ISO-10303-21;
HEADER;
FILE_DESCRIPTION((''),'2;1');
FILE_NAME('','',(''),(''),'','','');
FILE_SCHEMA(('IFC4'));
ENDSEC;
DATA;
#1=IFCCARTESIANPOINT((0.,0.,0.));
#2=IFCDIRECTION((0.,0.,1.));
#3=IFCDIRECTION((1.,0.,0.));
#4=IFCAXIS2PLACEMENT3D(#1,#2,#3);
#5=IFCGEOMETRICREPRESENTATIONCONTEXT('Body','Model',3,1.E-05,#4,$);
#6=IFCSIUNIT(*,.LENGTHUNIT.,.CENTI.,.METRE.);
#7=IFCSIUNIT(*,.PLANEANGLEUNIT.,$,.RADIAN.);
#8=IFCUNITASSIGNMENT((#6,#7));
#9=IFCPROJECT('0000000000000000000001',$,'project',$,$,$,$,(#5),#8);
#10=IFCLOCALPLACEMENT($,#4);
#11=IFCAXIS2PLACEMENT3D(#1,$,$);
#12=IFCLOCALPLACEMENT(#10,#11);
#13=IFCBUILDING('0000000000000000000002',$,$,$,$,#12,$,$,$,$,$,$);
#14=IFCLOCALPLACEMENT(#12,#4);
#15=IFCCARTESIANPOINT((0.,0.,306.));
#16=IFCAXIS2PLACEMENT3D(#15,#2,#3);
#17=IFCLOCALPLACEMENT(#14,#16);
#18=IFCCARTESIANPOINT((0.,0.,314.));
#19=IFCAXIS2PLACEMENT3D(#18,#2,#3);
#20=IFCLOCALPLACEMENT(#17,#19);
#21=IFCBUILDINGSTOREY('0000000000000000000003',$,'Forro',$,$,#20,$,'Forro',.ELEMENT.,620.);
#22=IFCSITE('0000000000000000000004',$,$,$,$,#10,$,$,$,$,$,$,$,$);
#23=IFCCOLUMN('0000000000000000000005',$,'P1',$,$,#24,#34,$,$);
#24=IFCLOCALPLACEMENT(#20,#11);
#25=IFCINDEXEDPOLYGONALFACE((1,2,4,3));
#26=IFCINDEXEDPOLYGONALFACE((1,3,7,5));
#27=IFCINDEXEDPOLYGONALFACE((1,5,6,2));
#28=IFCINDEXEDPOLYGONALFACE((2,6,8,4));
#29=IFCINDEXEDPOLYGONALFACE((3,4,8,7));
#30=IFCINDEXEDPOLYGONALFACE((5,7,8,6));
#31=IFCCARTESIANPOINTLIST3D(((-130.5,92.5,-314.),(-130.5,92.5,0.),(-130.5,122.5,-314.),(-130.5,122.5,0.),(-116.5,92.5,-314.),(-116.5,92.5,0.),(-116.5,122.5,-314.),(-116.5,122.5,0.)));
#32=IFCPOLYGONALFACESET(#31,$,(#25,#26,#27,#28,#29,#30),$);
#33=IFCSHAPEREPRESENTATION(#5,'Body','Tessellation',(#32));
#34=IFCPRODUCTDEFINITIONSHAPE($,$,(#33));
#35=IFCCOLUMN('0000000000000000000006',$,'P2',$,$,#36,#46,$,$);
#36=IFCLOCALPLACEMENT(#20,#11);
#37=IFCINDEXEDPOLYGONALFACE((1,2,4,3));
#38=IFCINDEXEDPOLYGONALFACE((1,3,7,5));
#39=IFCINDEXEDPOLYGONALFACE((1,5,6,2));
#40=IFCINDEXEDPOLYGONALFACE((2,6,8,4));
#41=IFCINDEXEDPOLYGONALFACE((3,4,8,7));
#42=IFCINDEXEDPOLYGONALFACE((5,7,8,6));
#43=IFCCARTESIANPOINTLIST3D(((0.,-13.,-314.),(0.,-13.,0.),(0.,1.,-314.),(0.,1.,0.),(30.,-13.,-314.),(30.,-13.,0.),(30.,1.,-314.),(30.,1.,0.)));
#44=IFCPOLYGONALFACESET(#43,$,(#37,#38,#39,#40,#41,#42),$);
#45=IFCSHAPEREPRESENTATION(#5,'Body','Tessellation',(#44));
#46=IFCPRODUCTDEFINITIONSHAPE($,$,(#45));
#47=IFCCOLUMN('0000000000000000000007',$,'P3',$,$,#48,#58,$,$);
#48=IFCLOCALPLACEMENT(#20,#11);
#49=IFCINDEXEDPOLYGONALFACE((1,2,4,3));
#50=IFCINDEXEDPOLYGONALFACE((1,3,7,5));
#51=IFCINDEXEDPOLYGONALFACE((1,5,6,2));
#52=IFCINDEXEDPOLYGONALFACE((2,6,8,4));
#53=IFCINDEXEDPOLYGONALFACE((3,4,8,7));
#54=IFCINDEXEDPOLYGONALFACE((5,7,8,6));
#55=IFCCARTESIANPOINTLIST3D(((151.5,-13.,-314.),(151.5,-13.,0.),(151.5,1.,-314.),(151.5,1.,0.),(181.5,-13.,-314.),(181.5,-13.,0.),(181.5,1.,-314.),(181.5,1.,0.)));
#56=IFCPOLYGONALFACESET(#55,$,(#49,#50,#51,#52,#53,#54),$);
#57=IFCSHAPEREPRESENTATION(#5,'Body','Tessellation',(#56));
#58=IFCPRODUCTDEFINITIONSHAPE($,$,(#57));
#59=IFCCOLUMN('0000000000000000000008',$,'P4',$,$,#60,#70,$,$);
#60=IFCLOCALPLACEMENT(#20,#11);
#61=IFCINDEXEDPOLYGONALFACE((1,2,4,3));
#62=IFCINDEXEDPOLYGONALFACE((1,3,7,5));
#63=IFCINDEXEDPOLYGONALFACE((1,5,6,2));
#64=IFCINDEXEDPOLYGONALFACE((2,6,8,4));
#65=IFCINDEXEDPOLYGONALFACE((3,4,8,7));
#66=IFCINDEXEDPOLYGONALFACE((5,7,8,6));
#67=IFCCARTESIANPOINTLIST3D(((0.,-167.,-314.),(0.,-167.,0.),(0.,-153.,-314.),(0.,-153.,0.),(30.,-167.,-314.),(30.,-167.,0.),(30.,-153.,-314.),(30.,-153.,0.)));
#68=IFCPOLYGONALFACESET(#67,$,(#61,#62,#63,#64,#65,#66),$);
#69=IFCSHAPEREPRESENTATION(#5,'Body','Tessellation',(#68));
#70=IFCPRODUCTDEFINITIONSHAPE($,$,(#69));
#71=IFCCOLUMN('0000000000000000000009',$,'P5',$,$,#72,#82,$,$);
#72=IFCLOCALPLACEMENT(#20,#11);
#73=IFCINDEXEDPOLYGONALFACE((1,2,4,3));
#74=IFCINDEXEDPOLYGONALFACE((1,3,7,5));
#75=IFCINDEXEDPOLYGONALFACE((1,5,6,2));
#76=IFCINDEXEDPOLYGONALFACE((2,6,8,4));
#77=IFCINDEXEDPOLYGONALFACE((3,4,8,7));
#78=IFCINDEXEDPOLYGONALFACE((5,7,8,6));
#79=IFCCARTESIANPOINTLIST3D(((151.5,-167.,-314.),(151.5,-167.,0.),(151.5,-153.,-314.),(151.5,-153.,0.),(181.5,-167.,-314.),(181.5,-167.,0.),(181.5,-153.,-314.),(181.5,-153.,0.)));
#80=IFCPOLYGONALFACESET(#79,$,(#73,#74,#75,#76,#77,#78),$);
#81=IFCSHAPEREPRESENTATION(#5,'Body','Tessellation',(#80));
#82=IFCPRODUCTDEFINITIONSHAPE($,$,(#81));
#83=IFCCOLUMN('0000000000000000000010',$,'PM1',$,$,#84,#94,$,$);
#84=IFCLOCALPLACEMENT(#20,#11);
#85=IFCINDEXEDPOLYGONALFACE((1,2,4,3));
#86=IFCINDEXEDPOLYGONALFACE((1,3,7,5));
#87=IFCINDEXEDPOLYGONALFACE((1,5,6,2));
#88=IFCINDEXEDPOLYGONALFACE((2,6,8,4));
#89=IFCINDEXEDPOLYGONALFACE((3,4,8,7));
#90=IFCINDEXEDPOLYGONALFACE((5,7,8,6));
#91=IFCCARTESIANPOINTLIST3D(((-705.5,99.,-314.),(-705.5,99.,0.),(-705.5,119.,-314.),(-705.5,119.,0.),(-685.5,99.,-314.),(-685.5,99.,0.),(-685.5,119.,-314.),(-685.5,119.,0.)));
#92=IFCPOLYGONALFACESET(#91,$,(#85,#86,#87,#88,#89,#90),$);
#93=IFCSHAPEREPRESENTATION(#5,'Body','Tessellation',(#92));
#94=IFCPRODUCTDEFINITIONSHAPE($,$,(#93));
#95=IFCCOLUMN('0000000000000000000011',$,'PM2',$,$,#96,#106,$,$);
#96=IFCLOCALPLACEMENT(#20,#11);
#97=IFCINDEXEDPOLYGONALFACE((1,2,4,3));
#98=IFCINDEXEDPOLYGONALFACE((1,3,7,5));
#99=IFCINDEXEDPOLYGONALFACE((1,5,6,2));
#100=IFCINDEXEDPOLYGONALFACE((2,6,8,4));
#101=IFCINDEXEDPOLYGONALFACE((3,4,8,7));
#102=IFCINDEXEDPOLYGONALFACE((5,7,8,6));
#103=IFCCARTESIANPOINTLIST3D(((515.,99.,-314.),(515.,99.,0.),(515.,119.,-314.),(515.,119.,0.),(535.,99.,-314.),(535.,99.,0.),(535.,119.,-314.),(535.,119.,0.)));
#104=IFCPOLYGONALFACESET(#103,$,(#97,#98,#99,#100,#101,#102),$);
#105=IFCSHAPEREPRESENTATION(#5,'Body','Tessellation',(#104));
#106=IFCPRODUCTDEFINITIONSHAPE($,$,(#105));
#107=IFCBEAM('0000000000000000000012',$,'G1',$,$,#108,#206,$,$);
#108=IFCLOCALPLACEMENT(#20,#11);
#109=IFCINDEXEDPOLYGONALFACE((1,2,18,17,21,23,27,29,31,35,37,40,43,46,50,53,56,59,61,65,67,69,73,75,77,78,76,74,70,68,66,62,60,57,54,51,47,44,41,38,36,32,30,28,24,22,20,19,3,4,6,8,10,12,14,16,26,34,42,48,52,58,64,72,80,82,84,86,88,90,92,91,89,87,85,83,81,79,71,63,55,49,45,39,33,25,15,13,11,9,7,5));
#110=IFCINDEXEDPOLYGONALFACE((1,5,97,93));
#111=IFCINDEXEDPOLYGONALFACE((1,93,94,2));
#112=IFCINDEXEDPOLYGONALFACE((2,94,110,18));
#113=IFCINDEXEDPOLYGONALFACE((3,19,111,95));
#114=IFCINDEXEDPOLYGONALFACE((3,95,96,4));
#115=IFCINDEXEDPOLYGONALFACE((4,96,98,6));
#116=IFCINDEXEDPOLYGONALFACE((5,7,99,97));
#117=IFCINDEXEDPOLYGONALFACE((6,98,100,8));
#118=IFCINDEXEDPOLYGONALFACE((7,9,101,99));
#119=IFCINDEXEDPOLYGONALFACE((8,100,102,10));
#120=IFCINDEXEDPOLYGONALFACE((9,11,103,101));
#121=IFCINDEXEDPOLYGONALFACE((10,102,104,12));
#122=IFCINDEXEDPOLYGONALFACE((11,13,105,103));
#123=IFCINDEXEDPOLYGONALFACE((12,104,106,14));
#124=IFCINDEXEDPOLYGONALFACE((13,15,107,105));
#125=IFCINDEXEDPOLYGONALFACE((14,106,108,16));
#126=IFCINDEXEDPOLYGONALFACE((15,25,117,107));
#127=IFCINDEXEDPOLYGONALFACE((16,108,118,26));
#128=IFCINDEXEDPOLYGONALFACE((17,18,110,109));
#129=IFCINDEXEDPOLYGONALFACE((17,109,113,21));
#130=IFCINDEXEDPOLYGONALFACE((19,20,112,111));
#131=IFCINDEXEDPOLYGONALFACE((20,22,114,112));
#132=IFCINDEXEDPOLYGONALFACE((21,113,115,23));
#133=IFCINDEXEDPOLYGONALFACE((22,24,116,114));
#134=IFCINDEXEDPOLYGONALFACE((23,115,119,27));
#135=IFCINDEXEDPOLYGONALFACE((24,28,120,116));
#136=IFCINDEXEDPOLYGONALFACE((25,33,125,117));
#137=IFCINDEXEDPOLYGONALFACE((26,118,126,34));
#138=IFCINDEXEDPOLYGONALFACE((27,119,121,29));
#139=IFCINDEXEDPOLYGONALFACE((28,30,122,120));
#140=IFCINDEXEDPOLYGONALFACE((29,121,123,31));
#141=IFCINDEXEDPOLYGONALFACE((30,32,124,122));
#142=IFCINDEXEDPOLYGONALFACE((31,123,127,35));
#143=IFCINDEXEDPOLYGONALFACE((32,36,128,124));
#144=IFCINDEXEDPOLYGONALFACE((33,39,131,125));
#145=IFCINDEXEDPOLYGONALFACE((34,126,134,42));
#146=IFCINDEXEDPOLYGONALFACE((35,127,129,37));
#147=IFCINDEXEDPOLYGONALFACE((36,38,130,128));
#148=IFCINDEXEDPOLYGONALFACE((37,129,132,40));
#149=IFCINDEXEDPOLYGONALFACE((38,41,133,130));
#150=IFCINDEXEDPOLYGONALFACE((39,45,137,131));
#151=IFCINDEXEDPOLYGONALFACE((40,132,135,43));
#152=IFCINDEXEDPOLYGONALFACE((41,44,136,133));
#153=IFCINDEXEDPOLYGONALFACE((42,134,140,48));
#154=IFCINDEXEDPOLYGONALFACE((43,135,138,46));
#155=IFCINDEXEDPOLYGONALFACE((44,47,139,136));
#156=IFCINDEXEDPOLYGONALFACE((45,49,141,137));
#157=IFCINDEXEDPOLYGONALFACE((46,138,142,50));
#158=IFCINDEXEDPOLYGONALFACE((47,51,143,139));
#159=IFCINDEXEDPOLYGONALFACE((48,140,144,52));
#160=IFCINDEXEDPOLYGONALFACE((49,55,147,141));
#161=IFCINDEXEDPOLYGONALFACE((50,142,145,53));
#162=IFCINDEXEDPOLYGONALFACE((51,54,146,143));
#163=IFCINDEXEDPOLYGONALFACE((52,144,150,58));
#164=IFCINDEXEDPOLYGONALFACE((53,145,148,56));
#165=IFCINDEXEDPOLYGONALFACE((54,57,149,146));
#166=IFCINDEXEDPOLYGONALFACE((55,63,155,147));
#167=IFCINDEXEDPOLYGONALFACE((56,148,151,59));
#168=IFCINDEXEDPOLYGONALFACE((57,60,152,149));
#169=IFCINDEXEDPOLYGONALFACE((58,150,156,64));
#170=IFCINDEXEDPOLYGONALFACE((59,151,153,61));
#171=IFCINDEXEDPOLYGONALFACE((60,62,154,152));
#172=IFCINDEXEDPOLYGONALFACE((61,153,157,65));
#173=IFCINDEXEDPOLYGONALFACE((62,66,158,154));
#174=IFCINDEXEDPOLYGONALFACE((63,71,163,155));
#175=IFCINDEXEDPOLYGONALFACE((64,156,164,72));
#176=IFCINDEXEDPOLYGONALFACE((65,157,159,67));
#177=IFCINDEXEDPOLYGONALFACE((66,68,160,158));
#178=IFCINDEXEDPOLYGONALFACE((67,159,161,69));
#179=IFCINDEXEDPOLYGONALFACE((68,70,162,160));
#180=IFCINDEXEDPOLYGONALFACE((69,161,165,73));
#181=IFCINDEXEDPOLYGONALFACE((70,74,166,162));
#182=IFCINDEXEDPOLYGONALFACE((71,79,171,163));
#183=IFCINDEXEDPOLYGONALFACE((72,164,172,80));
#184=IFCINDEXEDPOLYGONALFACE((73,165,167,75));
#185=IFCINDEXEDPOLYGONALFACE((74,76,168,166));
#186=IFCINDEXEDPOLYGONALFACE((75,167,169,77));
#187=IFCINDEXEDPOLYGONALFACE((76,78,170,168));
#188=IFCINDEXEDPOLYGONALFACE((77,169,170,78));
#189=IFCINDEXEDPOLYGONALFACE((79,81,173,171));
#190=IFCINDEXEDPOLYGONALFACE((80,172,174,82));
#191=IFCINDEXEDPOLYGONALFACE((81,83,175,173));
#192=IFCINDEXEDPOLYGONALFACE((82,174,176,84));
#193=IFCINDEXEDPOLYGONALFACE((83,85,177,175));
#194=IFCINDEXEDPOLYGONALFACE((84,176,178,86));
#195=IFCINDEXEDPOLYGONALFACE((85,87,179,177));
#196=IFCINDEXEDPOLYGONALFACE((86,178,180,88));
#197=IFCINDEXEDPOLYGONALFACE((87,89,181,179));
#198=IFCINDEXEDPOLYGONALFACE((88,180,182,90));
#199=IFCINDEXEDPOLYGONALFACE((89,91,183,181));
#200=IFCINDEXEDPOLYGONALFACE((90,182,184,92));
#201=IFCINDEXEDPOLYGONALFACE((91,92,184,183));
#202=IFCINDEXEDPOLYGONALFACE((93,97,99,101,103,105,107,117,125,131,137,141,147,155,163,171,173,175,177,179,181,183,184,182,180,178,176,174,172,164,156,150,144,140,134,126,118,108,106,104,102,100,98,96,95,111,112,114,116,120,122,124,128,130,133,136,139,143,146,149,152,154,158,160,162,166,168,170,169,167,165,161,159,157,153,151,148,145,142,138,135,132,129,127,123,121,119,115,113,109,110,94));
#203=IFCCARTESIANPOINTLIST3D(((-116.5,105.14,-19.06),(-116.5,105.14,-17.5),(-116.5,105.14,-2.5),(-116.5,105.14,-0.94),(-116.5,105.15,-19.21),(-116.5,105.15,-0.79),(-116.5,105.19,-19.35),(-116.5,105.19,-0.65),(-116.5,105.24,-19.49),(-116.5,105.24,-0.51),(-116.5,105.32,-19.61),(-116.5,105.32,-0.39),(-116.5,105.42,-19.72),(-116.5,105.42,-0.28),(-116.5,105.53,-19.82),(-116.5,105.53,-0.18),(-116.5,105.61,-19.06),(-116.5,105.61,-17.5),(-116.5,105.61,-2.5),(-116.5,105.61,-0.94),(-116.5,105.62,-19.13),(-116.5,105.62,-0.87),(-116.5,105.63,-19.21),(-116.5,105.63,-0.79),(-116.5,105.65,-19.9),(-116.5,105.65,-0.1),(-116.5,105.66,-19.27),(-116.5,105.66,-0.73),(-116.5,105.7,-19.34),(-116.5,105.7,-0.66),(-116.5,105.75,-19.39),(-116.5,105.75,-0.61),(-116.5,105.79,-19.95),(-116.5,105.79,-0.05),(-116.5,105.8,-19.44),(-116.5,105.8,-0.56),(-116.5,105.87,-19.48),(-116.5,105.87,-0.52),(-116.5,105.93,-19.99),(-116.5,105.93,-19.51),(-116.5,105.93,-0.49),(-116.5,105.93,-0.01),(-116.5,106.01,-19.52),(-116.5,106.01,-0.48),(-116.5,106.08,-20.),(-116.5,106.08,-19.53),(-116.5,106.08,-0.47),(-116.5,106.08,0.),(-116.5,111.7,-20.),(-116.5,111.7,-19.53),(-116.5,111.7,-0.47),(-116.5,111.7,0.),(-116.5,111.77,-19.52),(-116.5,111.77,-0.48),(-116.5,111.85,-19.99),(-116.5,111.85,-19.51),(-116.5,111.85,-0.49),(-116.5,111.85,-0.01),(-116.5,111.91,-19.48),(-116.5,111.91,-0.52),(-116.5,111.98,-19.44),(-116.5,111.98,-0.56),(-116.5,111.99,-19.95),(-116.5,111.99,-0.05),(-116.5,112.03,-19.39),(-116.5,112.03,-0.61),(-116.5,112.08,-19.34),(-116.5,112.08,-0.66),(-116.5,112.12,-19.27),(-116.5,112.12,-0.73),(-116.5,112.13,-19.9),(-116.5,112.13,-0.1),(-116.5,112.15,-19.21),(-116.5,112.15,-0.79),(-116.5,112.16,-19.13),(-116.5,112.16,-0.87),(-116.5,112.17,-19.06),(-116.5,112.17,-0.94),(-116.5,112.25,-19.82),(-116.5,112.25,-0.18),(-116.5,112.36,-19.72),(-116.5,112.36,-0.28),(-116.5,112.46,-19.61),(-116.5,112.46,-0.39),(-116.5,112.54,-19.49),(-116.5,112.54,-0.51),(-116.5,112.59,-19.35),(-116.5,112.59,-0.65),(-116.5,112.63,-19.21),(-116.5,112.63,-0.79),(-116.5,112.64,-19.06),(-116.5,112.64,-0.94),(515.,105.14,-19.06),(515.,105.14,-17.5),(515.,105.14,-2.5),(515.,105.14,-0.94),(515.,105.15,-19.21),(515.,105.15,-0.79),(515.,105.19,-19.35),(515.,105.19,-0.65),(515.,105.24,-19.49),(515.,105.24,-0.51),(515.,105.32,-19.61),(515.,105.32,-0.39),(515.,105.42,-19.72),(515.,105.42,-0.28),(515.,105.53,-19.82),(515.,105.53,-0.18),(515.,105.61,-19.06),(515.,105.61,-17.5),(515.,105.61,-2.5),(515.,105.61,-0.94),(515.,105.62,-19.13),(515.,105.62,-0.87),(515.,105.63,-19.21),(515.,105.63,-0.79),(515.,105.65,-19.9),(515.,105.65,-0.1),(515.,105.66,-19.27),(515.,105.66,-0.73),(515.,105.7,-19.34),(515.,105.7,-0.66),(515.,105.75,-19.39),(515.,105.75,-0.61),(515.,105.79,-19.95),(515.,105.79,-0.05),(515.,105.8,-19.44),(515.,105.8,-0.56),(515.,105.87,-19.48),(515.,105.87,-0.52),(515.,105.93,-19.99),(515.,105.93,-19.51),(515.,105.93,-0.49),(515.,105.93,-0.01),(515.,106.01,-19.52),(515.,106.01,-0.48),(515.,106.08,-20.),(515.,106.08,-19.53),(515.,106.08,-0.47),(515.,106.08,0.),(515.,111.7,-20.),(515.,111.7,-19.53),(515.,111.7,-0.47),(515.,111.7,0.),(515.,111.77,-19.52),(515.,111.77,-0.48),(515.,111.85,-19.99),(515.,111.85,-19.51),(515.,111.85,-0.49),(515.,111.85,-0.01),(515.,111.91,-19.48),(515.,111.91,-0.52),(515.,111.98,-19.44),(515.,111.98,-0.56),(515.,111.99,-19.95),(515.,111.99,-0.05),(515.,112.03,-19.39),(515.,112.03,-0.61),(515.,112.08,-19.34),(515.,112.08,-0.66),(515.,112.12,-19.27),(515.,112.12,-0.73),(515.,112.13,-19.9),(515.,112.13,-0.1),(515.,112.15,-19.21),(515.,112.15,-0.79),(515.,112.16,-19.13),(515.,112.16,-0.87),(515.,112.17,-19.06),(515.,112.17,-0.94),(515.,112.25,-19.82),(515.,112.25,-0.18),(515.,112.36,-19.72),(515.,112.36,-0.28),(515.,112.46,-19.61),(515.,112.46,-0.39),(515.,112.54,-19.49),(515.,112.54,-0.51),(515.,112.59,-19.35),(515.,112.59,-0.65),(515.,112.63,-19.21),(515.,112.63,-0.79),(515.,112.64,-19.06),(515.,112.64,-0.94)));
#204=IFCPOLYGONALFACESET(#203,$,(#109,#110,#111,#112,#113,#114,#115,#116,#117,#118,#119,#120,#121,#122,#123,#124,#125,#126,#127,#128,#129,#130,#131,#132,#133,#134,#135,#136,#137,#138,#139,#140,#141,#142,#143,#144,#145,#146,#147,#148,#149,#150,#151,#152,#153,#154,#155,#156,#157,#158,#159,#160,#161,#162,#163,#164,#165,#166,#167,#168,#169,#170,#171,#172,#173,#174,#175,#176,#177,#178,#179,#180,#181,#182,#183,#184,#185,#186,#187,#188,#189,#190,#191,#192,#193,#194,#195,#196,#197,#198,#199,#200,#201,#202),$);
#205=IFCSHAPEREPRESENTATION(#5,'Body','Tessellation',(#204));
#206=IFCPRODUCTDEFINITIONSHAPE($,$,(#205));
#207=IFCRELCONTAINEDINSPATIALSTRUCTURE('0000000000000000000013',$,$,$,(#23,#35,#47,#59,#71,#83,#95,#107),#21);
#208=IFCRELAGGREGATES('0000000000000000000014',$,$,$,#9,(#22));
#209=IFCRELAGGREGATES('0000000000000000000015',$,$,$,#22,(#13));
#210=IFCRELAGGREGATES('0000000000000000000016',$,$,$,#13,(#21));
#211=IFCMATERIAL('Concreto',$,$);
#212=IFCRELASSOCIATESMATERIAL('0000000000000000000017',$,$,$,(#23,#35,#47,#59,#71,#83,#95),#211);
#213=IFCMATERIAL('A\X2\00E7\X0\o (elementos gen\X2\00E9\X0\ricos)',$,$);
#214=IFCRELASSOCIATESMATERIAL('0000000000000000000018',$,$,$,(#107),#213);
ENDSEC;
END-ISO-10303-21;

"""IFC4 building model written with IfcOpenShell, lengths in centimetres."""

from ifc_helpers import new_model, si_unit, frame, origin, origin_with_axes, origin_2d_with_axis, place, context, project, spatial, polyline, rectangle, outline, extrude, material, element, save


model = new_model("IFC4")

# Units and contexts
model_context = context("Model", 3, precision=1e-05, world=origin_with_axes(), identifier="Body")
ifc_project = project(units=[si_unit("LENGTHUNIT", "METRE", prefix="CENTI"), si_unit("PLANEANGLEUNIT", "RADIAN")], contexts=[model_context])

# Site, building, storey
site_placement = place(None, origin_with_axes())
site = spatial("IfcSite", under=ifc_project, at=site_placement)
building_placement = place(site_placement, origin())
building = spatial("IfcBuilding", under=site, at=building_placement)
placement_1 = place(building_placement, origin_with_axes())
placement_2 = place(placement_1, frame((0.0, 0.0, 306.0), z_axis=(0.0, 0.0, 1.0), x_axis=(1.0, 0.0, 0.0)))
storey_placement = place(placement_2, frame((0.0, 0.0, 314.0), z_axis=(0.0, 0.0, 1.0), x_axis=(1.0, 0.0, 0.0)))
storey = spatial("IfcBuildingStorey", under=building, at=storey_placement, Name="Forro", LongName="Forro", CompositionType="ELEMENT", Elevation=620.0)

# Columns
ifc_material_1 = material(Name="Concreto")
column_placement = place(storey_placement, frame((-123.5, 107.5, 0.0), z_axis=(0.0, 0.0, 1.0), x_axis=(1.0, 0.0, 0.0)))
element("IfcColumn", 1, at=column_placement, inside=storey, material=ifc_material_1, Name="P1", context=model_context, shape_type="SolidModel", body=[
    extrude(rectangle(XDim=14.0, YDim=30.0, at=origin_2d_with_axis()), origin_with_axes(), (0.0, 0.0, -1.0), 314.0),
])
for number, where, z_axis, x_axis, name in (
    (2, (15.0, -6.0, 0.0), (0.0, 0.0, 1.0), (1.0, 0.0, 0.0), "P2"),
    (3, (166.5, -6.0, 0.0), (0.0, 0.0, 1.0), (1.0, 0.0, 0.0), "P3"),
    (4, (15.0, -160.0, 0.0), (0.0, 0.0, 1.0), (1.0, 0.0, 0.0), "P4"),
    (5, (166.5, -160.0, 0.0), (0.0, 0.0, 1.0), (1.0, 0.0, 0.0), "P5"),
):
    element("IfcColumn", number, at=place(storey_placement, frame(where, z_axis=z_axis, x_axis=x_axis)), inside=storey, material=ifc_material_1, Name=name, context=model_context, shape_type="SolidModel", body=[
        extrude(rectangle(XDim=14.0, YDim=30.0, at=origin_2d_with_axis()), frame((0.0, 0.0, 0.0), z_axis=(0.0, 0.0, 1.0), x_axis=(0.0, 1.0, 0.0)), (0.0, 0.0, -1.0), 314.0),
    ])
for number, where, z_axis, x_axis, name in (
    (6, (-695.5, 109.0, 0.0), (0.0, 0.0, 1.0), (1.0, 0.0, 0.0), "PM1"),
    (7, (525.0, 109.0, 0.0), (0.0, 0.0, 1.0), (1.0, 0.0, 0.0), "PM2"),
):
    element("IfcColumn", number, at=place(storey_placement, frame(where, z_axis=z_axis, x_axis=x_axis)), inside=storey, material=ifc_material_1, Name=name, context=model_context, shape_type="SolidModel", body=[
        extrude(rectangle(XDim=20.0, YDim=20.0, at=origin_2d_with_axis()), origin_with_axes(), (0.0, 0.0, -1.0), 314.0),
    ])

# Beam
ifc_material_2 = material(Name="Aço (elementos genéricos)")
beam_1_placement = place(storey_placement, frame((199.25, 108.89, 0.0), z_axis=(0.0, 0.0, 1.0), x_axis=(1.0, 0.0, 0.0)))
element("IfcBeam", 8, at=beam_1_placement, inside=storey, material=ifc_material_2, Name="G1", context=model_context, shape_type="SolidModel", body=[
    extrude(outline(polyline([(3.75, 9.06), (3.74, 9.21), (3.7, 9.35), (3.65, 9.49), (3.57, 9.61), (3.47, 9.72), (3.36, 9.82), (3.24, 9.9), (3.1, 9.95), (2.96, 9.99), (2.81, 10.0), (-2.81, 10.0), (-2.96, 9.99), (-3.1, 9.95), (-3.24, 9.9), (-3.36, 9.82), (-3.47, 9.72), (-3.57, 9.61), (-3.65, 9.49), (-3.7, 9.35), (-3.74, 9.21), (-3.75, 9.06), (-3.75, 7.5), (-3.28, 7.5), (-3.28, 9.06), (-3.27, 9.13), (-3.26, 9.21), (-3.23, 9.27), (-3.19, 9.34), (-3.14, 9.39), (-3.09, 9.44), (-3.02, 9.48), (-2.96, 9.51), (-2.88, 9.52), (-2.81, 9.53), (2.81, 9.53), (2.88, 9.52), (2.96, 9.51), (3.02, 9.48), (3.09, 9.44), (3.14, 9.39), (3.19, 9.34), (3.23, 9.27), (3.26, 9.21), (3.27, 9.13), (3.28, 9.06), (3.28, -9.06), (3.27, -9.13), (3.26, -9.21), (3.23, -9.27), (3.19, -9.34), (3.14, -9.39), (3.09, -9.44), (3.02, -9.48), (2.96, -9.51), (2.88, -9.52), (2.81, -9.53), (-2.81, -9.53), (-2.88, -9.52), (-2.96, -9.51), (-3.02, -9.48), (-3.09, -9.44), (-3.14, -9.39), (-3.19, -9.34), (-3.23, -9.27), (-3.26, -9.21), (-3.27, -9.13), (-3.28, -9.06), (-3.28, -7.5), (-3.75, -7.5), (-3.75, -9.06), (-3.74, -9.21), (-3.7, -9.35), (-3.65, -9.49), (-3.57, -9.61), (-3.47, -9.72), (-3.36, -9.82), (-3.24, -9.9), (-3.1, -9.95), (-2.96, -9.99), (-2.81, -10.0), (2.81, -10.0), (2.96, -9.99), (3.1, -9.95), (3.24, -9.9), (3.36, -9.82), (3.47, -9.72), (3.57, -9.61), (3.65, -9.49), (3.7, -9.35), (3.74, -9.21), (3.75, -9.06), (3.75, 9.06)])), frame((-315.75, 0.0, -10.0), z_axis=(1.0, 0.0, 0.0), x_axis=(0.0, 1.0, 0.0)), (0.0, 0.0, 1.0), 631.5),
])

save(model, "model.ifc")
